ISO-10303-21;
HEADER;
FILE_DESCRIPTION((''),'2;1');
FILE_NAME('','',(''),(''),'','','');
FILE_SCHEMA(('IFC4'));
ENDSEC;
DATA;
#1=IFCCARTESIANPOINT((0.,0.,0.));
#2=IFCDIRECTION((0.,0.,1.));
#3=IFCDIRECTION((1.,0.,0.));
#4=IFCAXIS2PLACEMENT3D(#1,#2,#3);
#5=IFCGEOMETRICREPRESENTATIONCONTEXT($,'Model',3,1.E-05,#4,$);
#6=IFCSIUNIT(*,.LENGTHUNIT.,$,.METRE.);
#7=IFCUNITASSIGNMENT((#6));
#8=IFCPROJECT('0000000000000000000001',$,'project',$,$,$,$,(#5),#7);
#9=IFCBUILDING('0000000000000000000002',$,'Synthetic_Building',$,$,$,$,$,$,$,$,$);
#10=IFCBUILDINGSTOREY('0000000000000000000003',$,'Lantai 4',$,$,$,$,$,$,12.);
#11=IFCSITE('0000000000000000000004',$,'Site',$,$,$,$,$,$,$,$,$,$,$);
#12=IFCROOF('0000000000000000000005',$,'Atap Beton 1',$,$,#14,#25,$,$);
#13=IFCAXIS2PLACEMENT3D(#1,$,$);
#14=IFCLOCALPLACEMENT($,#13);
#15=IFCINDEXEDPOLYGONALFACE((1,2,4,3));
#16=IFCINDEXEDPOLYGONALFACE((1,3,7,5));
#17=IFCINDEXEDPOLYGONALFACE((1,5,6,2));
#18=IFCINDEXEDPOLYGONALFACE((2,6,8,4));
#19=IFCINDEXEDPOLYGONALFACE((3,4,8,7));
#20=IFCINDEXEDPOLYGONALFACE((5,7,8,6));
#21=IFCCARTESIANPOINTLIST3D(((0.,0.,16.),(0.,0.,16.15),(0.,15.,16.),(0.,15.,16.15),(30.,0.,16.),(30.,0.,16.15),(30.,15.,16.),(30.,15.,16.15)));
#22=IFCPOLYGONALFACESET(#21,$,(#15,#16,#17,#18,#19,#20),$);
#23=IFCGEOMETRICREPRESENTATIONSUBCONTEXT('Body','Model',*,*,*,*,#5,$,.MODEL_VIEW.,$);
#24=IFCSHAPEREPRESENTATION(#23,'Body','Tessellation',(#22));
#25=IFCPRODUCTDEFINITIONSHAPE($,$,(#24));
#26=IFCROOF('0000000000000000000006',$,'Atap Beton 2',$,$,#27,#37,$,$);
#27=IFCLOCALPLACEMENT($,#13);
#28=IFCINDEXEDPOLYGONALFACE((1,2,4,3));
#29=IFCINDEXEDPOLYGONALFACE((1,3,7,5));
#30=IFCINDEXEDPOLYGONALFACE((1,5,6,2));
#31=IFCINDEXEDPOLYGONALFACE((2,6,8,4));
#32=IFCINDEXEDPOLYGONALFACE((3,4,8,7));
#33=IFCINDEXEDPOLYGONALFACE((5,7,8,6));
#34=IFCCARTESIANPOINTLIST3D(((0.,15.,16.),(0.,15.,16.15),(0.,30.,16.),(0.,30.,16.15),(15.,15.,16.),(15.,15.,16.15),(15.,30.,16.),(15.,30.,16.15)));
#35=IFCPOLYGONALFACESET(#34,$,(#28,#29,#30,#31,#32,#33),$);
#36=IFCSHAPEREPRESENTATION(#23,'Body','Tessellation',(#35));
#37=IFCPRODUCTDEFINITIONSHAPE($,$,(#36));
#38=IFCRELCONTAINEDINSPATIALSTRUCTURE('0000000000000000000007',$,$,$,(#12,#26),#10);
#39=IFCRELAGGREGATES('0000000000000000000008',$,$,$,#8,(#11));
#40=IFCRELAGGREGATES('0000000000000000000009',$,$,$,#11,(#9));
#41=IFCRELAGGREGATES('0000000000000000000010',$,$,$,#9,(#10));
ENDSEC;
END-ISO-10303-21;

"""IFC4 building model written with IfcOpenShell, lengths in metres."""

from ifc_helpers import new_model, si_unit, frame, origin_with_axes, place, context, subcontext, project, spatial, polyline, outline, extrude, element, save


model = new_model("IFC4")

# Units and contexts
model_context = context("Model", 3, precision=1e-05, world=origin_with_axes())
body_context = subcontext(model_context, "Body", "Model", "MODEL_VIEW")
ifc_project = project(units=[si_unit("LENGTHUNIT", "METRE")], contexts=[model_context])

# Site, building, storey
site = spatial("IfcSite", under=ifc_project, Name="Site")
building = spatial("IfcBuilding", under=site, Name="Synthetic_Building")
storey = spatial("IfcBuildingStorey", under=building, Name="Lantai 4", Elevation=12.0)

# Roofs
roof_1_placement = place(None, origin_with_axes())
element("IfcRoof", 1, at=roof_1_placement, inside=storey, Name="Atap Beton 1", context=body_context, shape_type="SweptSolid", body=[
    extrude(outline(polyline([(0.0, 0.0), (30.0, 0.0), (30.0, 15.0), (0.0, 15.0), (0.0, 0.0)])), frame((0.0, 0.0, 16.0), z_axis=(0.0, 0.0, 1.0), x_axis=(1.0, 0.0, 0.0)), (0.0, 0.0, 1.0), 0.15),
])
roof_2_placement = place(None, origin_with_axes())
element("IfcRoof", 2, at=roof_2_placement, inside=storey, Name="Atap Beton 2", context=body_context, shape_type="SweptSolid", body=[
    extrude(outline(polyline([(0.0, 15.0), (15.0, 15.0), (15.0, 30.0), (0.0, 30.0), (0.0, 15.0)])), frame((0.0, 0.0, 16.0), z_axis=(0.0, 0.0, 1.0), x_axis=(1.0, 0.0, 0.0)), (0.0, 0.0, 1.0), 0.15),
])

save(model, "model.ifc")
